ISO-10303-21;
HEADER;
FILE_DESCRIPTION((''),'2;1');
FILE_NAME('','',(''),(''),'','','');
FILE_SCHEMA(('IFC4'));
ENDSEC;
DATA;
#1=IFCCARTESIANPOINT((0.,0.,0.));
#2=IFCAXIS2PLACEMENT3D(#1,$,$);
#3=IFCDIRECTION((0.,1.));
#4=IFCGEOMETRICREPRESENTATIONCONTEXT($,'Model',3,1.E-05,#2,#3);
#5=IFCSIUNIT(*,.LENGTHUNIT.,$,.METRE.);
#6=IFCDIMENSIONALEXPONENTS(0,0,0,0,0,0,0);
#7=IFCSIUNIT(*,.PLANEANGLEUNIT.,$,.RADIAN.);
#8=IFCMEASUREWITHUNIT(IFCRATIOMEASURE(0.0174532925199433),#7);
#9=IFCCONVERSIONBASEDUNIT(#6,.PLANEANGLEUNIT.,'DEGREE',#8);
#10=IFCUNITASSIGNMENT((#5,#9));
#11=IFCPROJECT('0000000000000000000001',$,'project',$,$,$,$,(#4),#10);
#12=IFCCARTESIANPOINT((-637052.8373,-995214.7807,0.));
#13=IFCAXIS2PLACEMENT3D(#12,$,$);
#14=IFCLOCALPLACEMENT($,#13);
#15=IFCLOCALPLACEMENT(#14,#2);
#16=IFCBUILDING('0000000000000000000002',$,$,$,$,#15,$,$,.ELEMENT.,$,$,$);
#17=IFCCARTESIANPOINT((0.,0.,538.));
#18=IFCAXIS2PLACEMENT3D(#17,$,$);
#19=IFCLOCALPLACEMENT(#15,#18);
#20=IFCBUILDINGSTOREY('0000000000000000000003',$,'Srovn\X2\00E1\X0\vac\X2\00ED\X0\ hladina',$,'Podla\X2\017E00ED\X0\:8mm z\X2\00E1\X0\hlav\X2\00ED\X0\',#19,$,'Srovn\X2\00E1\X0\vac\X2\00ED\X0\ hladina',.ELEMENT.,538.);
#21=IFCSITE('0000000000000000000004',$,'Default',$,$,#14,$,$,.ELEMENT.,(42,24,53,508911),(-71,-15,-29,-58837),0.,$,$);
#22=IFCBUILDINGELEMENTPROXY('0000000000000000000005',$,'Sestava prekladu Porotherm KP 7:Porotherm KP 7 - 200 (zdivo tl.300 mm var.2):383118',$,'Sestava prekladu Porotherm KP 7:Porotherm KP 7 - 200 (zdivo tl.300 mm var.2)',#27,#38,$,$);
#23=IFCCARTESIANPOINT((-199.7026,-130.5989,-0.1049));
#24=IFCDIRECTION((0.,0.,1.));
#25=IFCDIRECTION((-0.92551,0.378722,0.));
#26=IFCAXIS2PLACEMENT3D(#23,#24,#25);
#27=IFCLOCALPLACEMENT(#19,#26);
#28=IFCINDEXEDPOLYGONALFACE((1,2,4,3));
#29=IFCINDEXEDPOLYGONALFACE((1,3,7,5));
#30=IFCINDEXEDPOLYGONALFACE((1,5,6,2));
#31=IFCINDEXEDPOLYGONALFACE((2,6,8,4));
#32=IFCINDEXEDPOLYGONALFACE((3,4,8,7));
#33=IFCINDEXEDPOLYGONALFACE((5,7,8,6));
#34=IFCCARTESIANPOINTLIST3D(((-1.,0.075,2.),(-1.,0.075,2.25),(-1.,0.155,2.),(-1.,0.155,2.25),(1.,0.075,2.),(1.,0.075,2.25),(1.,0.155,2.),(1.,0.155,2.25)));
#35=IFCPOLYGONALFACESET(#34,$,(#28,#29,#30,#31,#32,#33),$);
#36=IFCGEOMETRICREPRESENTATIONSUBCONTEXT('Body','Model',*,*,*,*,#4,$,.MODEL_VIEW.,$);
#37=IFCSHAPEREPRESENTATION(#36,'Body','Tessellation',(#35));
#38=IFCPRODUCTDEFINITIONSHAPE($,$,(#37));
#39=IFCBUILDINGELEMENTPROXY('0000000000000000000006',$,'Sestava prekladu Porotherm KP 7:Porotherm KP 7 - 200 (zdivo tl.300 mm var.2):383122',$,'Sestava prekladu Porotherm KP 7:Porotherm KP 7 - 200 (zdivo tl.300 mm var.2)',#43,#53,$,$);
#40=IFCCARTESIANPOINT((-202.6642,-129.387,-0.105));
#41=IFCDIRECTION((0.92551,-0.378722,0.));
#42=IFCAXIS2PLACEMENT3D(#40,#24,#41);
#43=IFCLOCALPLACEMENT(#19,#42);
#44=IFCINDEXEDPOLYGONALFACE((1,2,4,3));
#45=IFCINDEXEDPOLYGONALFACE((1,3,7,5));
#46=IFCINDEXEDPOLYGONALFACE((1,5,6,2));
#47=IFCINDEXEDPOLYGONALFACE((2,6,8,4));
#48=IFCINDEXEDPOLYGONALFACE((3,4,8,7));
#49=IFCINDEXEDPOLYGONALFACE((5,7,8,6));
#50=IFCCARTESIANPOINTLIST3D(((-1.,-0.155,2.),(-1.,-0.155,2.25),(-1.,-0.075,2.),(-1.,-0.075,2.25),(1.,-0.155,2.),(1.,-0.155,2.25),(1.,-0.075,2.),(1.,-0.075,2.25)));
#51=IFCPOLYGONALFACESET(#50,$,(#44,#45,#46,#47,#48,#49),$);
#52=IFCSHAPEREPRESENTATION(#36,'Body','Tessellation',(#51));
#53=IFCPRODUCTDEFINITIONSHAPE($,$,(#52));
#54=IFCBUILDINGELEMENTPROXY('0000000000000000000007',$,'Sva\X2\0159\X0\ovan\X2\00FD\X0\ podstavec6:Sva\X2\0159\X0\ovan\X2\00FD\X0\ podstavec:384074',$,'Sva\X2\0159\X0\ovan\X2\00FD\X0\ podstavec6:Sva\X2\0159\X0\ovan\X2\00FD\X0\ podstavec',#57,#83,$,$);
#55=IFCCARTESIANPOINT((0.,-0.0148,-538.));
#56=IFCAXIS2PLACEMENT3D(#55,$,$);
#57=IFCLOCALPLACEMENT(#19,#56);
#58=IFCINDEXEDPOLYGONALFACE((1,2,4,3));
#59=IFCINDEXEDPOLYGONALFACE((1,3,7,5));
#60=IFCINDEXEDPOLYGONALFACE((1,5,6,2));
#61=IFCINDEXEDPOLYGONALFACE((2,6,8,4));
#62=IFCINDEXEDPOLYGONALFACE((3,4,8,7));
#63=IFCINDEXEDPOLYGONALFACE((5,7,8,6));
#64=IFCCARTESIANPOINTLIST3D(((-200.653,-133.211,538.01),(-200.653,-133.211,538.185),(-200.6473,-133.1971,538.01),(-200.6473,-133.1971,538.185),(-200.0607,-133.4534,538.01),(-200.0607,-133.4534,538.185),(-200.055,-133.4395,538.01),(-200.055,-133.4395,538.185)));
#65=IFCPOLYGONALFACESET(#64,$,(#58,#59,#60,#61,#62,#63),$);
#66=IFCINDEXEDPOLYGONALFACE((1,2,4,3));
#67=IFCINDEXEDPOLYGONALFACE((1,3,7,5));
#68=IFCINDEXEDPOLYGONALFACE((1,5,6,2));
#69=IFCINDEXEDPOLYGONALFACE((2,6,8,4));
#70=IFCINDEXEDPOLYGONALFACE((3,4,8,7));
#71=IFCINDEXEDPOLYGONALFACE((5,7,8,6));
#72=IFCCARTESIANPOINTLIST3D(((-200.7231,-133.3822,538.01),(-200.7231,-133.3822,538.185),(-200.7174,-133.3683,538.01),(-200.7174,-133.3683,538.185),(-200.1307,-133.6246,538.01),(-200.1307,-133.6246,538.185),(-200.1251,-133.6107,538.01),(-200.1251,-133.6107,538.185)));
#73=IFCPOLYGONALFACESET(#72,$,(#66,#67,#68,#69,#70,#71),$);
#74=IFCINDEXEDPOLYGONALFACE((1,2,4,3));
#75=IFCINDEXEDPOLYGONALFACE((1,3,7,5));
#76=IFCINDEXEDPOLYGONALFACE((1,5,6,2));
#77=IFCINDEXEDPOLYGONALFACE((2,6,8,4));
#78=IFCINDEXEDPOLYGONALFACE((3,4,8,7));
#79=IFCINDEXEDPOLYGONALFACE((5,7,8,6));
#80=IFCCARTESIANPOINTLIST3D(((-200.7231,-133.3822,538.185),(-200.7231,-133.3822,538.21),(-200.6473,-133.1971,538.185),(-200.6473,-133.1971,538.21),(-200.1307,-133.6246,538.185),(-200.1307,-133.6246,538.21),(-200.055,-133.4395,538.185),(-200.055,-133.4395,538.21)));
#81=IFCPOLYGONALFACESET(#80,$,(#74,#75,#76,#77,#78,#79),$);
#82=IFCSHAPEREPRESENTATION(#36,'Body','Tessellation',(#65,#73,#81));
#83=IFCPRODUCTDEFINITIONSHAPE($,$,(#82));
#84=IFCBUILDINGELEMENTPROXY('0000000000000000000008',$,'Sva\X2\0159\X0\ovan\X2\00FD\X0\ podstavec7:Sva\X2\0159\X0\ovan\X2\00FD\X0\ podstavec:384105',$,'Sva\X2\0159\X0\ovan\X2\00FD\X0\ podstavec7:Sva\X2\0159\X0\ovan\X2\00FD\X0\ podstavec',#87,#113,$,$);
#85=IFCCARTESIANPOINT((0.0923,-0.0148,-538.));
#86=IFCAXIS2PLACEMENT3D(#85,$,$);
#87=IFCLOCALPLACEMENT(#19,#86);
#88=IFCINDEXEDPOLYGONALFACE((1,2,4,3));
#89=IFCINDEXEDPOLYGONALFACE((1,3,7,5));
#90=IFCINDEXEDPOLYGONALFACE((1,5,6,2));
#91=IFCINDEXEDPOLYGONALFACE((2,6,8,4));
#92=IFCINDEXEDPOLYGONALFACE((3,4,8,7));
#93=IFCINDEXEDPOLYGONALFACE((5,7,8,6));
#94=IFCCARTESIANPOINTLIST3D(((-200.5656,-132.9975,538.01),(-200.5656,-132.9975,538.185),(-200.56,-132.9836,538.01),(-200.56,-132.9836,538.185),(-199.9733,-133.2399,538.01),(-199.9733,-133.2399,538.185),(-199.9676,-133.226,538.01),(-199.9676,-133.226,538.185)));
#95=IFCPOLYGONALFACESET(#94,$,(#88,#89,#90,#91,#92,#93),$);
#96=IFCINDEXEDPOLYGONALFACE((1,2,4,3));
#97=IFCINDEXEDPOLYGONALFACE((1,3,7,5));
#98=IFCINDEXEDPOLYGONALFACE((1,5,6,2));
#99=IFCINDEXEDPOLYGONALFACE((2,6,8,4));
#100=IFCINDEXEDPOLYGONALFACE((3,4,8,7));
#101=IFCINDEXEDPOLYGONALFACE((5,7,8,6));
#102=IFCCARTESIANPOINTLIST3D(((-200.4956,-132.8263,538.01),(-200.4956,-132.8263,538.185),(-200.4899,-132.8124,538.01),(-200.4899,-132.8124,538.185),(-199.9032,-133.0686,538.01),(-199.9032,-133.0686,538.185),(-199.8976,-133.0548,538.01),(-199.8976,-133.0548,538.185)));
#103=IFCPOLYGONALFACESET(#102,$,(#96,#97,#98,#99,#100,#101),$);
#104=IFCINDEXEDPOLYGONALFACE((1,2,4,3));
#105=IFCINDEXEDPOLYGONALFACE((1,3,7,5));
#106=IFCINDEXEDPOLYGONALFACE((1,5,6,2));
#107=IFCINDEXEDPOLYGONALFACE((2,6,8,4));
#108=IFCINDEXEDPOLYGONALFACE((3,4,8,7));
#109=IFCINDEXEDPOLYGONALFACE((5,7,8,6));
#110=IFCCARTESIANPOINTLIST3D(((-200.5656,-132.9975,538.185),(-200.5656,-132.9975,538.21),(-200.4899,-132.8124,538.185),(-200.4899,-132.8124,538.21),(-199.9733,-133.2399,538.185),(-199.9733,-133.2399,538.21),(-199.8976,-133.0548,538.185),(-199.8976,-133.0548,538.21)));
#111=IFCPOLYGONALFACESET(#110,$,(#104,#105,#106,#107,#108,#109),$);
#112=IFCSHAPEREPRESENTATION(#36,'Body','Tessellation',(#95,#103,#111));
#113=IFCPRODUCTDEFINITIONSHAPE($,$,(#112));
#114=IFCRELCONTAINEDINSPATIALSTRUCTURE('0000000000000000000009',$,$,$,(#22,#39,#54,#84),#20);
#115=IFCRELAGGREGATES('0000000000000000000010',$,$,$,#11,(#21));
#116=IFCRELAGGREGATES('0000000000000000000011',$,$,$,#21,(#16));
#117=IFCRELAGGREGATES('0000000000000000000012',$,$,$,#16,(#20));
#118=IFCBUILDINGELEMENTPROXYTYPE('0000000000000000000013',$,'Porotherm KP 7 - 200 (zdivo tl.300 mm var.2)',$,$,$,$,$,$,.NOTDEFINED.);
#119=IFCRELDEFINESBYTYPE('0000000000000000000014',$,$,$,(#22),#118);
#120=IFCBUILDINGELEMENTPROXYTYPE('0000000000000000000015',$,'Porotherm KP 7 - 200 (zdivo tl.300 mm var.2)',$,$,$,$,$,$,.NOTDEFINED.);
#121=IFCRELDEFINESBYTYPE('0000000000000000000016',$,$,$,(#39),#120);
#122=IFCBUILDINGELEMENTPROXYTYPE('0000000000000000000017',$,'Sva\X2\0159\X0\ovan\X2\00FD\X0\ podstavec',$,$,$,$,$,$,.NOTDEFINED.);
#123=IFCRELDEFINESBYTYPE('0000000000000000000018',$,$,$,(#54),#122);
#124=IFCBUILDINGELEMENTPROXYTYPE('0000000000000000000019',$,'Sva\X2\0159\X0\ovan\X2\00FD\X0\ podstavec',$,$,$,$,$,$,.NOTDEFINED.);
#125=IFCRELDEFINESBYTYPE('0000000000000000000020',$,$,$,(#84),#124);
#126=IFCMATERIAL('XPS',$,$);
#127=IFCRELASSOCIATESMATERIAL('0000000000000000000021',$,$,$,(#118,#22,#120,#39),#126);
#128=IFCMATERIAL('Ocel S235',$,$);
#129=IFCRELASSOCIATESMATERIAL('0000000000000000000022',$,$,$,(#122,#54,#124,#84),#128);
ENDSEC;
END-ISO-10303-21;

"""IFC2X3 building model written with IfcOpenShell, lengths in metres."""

from ifc_helpers import new_model, entity, si_unit, converted_unit, direction, frame, frame_2d, origin, origin_2d_with_axis, place, context, subcontext, project, spatial, rectangle, extrude, source, transform, mapped, material, type_object, type_shapes, element, save


model = new_model("IFC2X3")

# Units and contexts
model_context = context("Model", 3, precision=1e-05, world=origin(), true_north=direction((0.0, 1.0)))
body_context = subcontext(model_context, "Body", "Model", "MODEL_VIEW")
ifc_project = project(units=[si_unit("LENGTHUNIT", "METRE"), converted_unit("PLANEANGLEUNIT", "DEGREE", entity("IfcRatioMeasure", 0.0174532925199433), si_unit("PLANEANGLEUNIT", "RADIAN"), dimensions=[0, 0, 0, 0, 0, 0, 0])], contexts=[model_context])

# Site, building, storey
site_placement = place(None, frame((-637052.8373, -995214.7807, 0.0)))
site = spatial("IfcSite", under=ifc_project, at=site_placement, Name="Default", CompositionType="ELEMENT", RefLatitude=(42, 24, 53, 508911), RefLongitude=(-71, -15, -29, -58837), RefElevation=0.0)
building_placement = place(site_placement, origin())
building = spatial("IfcBuilding", under=site, at=building_placement, CompositionType="ELEMENT")
storey_placement = place(building_placement, frame((0.0, 0.0, 538.0)))
storey = spatial("IfcBuildingStorey", under=building, at=storey_placement, Name="Srovnávací hladina", ObjectType="Podlaží:8mm záhlaví", LongName="Srovnávací hladina", CompositionType="ELEMENT", Elevation=538.0)

# Shared definitions
ifc_material_1 = material(Name="Ocel S235")

# Building element proxies
ifc_material_2 = material(Name="XPS")
building_element_proxy_type_1 = type_object("IfcBuildingElementProxyType", Name="Porotherm KP 7 - 200 (zdivo tl.300 mm var.2)", PredefinedType="NOTDEFINED", material=ifc_material_2)
shared_shape_1 = source(origin(), body_context, "Body", "SweptSolid", [
    extrude(rectangle(XDim=2.0, YDim=0.08, at=origin_2d_with_axis()), frame((0.0, 0.115, 2.0), z_axis=(0.0, 0.0, 1.0), x_axis=(-1.0, 0.0, 0.0)), (0.0, 0.0, 1.0), 0.25),
])
type_shapes(building_element_proxy_type_1, [shared_shape_1])
proxy_1_placement = place(storey_placement, frame((-199.7026, -130.5989, -0.1049), z_axis=(0.0, 0.0, 1.0), x_axis=(-0.92551, 0.378722, 0.0)))
element("IfcBuildingElementProxy", 1, at=proxy_1_placement, inside=storey, type_object=building_element_proxy_type_1, material=ifc_material_2, Name="Sestava prekladu Porotherm KP 7:Porotherm KP 7 - 200 (zdivo tl.300 mm var.2):383118", ObjectType="Sestava prekladu Porotherm KP 7:Porotherm KP 7 - 200 (zdivo tl.300 mm var.2)", context=body_context, shape_type="MappedRepresentation", body=[
    mapped(shared_shape_1, transform((0.0, 0.0, 0.0), scale=1.0)),
])
building_element_proxy_type_2 = type_object("IfcBuildingElementProxyType", Name="Porotherm KP 7 - 200 (zdivo tl.300 mm var.2)", PredefinedType="NOTDEFINED", material=ifc_material_2)
shared_shape_2 = source(origin(), body_context, "Body", "SweptSolid", [
    extrude(rectangle(XDim=0.08, YDim=2.0, at=frame_2d((0.0, 0.0), x_axis=(1.0, 0.0))), frame((0.0, -0.115, 2.0), z_axis=(0.0, 0.0, 1.0), x_axis=(0.0, 1.0, 0.0)), (0.0, 0.0, 1.0), 0.25),
])
type_shapes(building_element_proxy_type_2, [shared_shape_2])
proxy_2_placement = place(storey_placement, frame((-202.6642, -129.387, -0.105), z_axis=(0.0, 0.0, 1.0), x_axis=(0.92551, -0.378722, 0.0)))
element("IfcBuildingElementProxy", 2, at=proxy_2_placement, inside=storey, type_object=building_element_proxy_type_2, material=ifc_material_2, Name="Sestava prekladu Porotherm KP 7:Porotherm KP 7 - 200 (zdivo tl.300 mm var.2):383122", ObjectType="Sestava prekladu Porotherm KP 7:Porotherm KP 7 - 200 (zdivo tl.300 mm var.2)", context=body_context, shape_type="MappedRepresentation", body=[
    mapped(shared_shape_2, transform((0.0, 0.0, 0.0), scale=1.0)),
])
building_element_proxy_type_3 = type_object("IfcBuildingElementProxyType", Name="Svařovaný podstavec", PredefinedType="NOTDEFINED", material=ifc_material_1)
shared_shape_3 = source(origin(), body_context, "Body", "SweptSolid", [
    extrude(rectangle(XDim=0.64, YDim=0.015, at=frame_2d((0.0, 0.0), x_axis=(1.0, 0.0))), frame((-200.354, -133.3252, 538.01), z_axis=(0.0, 0.0, 1.0), x_axis=(-0.92551, 0.378722, 0.0)), (0.0, 0.0, 1.0), 0.175),
    extrude(rectangle(XDim=0.64, YDim=0.015, at=origin_2d_with_axis()), frame((-200.4241, -133.4965, 538.01), z_axis=(0.0, 0.0, 1.0), x_axis=(-0.92551, 0.378722, 0.0)), (0.0, 0.0, 1.0), 0.175),
    extrude(rectangle(XDim=0.64, YDim=0.2, at=frame_2d((0.0, 0.0), x_axis=(1.0, 0.0))), frame((-200.389, -133.4109, 538.185), z_axis=(0.0, 0.0, 1.0), x_axis=(-0.92551, 0.378722, 0.0)), (0.0, 0.0, 1.0), 0.025),
])
type_shapes(building_element_proxy_type_3, [shared_shape_3])
proxy_3_placement = place(storey_placement, frame((0.0, -0.0148, -538.0)))
element("IfcBuildingElementProxy", 3, at=proxy_3_placement, inside=storey, type_object=building_element_proxy_type_3, material=ifc_material_1, Name="Svařovaný podstavec6:Svařovaný podstavec:384074", ObjectType="Svařovaný podstavec6:Svařovaný podstavec", context=body_context, shape_type="MappedRepresentation", body=[
    mapped(shared_shape_3, transform((0.0, 0.0, 0.0), scale=1.0)),
])
building_element_proxy_type_4 = type_object("IfcBuildingElementProxyType", Name="Svařovaný podstavec", PredefinedType="NOTDEFINED", material=ifc_material_1)
shared_shape_4 = source(origin(), body_context, "Body", "SweptSolid", [
    extrude(rectangle(XDim=0.64, YDim=0.015, at=origin_2d_with_axis()), frame((-200.2666, -133.1117, 538.01), z_axis=(0.0, 0.0, 1.0), x_axis=(-0.92551, 0.378722, 0.0)), (0.0, 0.0, 1.0), 0.175),
    extrude(rectangle(XDim=0.64, YDim=0.015, at=origin_2d_with_axis()), frame((-200.1966, -132.9405, 538.01), z_axis=(0.0, 0.0, 1.0), x_axis=(-0.92551, 0.378722, 0.0)), (0.0, 0.0, 1.0), 0.175),
    extrude(rectangle(XDim=0.64, YDim=0.2, at=origin_2d_with_axis()), frame((-200.2316, -133.0261, 538.185), z_axis=(0.0, 0.0, 1.0), x_axis=(-0.92551, 0.378722, 0.0)), (0.0, 0.0, 1.0), 0.025),
])
type_shapes(building_element_proxy_type_4, [shared_shape_4])
proxy_4_placement = place(storey_placement, frame((0.0923, -0.0148, -538.0)))
element("IfcBuildingElementProxy", 4, at=proxy_4_placement, inside=storey, type_object=building_element_proxy_type_4, material=ifc_material_1, Name="Svařovaný podstavec7:Svařovaný podstavec:384105", ObjectType="Svařovaný podstavec7:Svařovaný podstavec", context=body_context, shape_type="MappedRepresentation", body=[
    mapped(shared_shape_4, transform((0.0, 0.0, 0.0), scale=1.0)),
])

save(model, "model.ifc")
